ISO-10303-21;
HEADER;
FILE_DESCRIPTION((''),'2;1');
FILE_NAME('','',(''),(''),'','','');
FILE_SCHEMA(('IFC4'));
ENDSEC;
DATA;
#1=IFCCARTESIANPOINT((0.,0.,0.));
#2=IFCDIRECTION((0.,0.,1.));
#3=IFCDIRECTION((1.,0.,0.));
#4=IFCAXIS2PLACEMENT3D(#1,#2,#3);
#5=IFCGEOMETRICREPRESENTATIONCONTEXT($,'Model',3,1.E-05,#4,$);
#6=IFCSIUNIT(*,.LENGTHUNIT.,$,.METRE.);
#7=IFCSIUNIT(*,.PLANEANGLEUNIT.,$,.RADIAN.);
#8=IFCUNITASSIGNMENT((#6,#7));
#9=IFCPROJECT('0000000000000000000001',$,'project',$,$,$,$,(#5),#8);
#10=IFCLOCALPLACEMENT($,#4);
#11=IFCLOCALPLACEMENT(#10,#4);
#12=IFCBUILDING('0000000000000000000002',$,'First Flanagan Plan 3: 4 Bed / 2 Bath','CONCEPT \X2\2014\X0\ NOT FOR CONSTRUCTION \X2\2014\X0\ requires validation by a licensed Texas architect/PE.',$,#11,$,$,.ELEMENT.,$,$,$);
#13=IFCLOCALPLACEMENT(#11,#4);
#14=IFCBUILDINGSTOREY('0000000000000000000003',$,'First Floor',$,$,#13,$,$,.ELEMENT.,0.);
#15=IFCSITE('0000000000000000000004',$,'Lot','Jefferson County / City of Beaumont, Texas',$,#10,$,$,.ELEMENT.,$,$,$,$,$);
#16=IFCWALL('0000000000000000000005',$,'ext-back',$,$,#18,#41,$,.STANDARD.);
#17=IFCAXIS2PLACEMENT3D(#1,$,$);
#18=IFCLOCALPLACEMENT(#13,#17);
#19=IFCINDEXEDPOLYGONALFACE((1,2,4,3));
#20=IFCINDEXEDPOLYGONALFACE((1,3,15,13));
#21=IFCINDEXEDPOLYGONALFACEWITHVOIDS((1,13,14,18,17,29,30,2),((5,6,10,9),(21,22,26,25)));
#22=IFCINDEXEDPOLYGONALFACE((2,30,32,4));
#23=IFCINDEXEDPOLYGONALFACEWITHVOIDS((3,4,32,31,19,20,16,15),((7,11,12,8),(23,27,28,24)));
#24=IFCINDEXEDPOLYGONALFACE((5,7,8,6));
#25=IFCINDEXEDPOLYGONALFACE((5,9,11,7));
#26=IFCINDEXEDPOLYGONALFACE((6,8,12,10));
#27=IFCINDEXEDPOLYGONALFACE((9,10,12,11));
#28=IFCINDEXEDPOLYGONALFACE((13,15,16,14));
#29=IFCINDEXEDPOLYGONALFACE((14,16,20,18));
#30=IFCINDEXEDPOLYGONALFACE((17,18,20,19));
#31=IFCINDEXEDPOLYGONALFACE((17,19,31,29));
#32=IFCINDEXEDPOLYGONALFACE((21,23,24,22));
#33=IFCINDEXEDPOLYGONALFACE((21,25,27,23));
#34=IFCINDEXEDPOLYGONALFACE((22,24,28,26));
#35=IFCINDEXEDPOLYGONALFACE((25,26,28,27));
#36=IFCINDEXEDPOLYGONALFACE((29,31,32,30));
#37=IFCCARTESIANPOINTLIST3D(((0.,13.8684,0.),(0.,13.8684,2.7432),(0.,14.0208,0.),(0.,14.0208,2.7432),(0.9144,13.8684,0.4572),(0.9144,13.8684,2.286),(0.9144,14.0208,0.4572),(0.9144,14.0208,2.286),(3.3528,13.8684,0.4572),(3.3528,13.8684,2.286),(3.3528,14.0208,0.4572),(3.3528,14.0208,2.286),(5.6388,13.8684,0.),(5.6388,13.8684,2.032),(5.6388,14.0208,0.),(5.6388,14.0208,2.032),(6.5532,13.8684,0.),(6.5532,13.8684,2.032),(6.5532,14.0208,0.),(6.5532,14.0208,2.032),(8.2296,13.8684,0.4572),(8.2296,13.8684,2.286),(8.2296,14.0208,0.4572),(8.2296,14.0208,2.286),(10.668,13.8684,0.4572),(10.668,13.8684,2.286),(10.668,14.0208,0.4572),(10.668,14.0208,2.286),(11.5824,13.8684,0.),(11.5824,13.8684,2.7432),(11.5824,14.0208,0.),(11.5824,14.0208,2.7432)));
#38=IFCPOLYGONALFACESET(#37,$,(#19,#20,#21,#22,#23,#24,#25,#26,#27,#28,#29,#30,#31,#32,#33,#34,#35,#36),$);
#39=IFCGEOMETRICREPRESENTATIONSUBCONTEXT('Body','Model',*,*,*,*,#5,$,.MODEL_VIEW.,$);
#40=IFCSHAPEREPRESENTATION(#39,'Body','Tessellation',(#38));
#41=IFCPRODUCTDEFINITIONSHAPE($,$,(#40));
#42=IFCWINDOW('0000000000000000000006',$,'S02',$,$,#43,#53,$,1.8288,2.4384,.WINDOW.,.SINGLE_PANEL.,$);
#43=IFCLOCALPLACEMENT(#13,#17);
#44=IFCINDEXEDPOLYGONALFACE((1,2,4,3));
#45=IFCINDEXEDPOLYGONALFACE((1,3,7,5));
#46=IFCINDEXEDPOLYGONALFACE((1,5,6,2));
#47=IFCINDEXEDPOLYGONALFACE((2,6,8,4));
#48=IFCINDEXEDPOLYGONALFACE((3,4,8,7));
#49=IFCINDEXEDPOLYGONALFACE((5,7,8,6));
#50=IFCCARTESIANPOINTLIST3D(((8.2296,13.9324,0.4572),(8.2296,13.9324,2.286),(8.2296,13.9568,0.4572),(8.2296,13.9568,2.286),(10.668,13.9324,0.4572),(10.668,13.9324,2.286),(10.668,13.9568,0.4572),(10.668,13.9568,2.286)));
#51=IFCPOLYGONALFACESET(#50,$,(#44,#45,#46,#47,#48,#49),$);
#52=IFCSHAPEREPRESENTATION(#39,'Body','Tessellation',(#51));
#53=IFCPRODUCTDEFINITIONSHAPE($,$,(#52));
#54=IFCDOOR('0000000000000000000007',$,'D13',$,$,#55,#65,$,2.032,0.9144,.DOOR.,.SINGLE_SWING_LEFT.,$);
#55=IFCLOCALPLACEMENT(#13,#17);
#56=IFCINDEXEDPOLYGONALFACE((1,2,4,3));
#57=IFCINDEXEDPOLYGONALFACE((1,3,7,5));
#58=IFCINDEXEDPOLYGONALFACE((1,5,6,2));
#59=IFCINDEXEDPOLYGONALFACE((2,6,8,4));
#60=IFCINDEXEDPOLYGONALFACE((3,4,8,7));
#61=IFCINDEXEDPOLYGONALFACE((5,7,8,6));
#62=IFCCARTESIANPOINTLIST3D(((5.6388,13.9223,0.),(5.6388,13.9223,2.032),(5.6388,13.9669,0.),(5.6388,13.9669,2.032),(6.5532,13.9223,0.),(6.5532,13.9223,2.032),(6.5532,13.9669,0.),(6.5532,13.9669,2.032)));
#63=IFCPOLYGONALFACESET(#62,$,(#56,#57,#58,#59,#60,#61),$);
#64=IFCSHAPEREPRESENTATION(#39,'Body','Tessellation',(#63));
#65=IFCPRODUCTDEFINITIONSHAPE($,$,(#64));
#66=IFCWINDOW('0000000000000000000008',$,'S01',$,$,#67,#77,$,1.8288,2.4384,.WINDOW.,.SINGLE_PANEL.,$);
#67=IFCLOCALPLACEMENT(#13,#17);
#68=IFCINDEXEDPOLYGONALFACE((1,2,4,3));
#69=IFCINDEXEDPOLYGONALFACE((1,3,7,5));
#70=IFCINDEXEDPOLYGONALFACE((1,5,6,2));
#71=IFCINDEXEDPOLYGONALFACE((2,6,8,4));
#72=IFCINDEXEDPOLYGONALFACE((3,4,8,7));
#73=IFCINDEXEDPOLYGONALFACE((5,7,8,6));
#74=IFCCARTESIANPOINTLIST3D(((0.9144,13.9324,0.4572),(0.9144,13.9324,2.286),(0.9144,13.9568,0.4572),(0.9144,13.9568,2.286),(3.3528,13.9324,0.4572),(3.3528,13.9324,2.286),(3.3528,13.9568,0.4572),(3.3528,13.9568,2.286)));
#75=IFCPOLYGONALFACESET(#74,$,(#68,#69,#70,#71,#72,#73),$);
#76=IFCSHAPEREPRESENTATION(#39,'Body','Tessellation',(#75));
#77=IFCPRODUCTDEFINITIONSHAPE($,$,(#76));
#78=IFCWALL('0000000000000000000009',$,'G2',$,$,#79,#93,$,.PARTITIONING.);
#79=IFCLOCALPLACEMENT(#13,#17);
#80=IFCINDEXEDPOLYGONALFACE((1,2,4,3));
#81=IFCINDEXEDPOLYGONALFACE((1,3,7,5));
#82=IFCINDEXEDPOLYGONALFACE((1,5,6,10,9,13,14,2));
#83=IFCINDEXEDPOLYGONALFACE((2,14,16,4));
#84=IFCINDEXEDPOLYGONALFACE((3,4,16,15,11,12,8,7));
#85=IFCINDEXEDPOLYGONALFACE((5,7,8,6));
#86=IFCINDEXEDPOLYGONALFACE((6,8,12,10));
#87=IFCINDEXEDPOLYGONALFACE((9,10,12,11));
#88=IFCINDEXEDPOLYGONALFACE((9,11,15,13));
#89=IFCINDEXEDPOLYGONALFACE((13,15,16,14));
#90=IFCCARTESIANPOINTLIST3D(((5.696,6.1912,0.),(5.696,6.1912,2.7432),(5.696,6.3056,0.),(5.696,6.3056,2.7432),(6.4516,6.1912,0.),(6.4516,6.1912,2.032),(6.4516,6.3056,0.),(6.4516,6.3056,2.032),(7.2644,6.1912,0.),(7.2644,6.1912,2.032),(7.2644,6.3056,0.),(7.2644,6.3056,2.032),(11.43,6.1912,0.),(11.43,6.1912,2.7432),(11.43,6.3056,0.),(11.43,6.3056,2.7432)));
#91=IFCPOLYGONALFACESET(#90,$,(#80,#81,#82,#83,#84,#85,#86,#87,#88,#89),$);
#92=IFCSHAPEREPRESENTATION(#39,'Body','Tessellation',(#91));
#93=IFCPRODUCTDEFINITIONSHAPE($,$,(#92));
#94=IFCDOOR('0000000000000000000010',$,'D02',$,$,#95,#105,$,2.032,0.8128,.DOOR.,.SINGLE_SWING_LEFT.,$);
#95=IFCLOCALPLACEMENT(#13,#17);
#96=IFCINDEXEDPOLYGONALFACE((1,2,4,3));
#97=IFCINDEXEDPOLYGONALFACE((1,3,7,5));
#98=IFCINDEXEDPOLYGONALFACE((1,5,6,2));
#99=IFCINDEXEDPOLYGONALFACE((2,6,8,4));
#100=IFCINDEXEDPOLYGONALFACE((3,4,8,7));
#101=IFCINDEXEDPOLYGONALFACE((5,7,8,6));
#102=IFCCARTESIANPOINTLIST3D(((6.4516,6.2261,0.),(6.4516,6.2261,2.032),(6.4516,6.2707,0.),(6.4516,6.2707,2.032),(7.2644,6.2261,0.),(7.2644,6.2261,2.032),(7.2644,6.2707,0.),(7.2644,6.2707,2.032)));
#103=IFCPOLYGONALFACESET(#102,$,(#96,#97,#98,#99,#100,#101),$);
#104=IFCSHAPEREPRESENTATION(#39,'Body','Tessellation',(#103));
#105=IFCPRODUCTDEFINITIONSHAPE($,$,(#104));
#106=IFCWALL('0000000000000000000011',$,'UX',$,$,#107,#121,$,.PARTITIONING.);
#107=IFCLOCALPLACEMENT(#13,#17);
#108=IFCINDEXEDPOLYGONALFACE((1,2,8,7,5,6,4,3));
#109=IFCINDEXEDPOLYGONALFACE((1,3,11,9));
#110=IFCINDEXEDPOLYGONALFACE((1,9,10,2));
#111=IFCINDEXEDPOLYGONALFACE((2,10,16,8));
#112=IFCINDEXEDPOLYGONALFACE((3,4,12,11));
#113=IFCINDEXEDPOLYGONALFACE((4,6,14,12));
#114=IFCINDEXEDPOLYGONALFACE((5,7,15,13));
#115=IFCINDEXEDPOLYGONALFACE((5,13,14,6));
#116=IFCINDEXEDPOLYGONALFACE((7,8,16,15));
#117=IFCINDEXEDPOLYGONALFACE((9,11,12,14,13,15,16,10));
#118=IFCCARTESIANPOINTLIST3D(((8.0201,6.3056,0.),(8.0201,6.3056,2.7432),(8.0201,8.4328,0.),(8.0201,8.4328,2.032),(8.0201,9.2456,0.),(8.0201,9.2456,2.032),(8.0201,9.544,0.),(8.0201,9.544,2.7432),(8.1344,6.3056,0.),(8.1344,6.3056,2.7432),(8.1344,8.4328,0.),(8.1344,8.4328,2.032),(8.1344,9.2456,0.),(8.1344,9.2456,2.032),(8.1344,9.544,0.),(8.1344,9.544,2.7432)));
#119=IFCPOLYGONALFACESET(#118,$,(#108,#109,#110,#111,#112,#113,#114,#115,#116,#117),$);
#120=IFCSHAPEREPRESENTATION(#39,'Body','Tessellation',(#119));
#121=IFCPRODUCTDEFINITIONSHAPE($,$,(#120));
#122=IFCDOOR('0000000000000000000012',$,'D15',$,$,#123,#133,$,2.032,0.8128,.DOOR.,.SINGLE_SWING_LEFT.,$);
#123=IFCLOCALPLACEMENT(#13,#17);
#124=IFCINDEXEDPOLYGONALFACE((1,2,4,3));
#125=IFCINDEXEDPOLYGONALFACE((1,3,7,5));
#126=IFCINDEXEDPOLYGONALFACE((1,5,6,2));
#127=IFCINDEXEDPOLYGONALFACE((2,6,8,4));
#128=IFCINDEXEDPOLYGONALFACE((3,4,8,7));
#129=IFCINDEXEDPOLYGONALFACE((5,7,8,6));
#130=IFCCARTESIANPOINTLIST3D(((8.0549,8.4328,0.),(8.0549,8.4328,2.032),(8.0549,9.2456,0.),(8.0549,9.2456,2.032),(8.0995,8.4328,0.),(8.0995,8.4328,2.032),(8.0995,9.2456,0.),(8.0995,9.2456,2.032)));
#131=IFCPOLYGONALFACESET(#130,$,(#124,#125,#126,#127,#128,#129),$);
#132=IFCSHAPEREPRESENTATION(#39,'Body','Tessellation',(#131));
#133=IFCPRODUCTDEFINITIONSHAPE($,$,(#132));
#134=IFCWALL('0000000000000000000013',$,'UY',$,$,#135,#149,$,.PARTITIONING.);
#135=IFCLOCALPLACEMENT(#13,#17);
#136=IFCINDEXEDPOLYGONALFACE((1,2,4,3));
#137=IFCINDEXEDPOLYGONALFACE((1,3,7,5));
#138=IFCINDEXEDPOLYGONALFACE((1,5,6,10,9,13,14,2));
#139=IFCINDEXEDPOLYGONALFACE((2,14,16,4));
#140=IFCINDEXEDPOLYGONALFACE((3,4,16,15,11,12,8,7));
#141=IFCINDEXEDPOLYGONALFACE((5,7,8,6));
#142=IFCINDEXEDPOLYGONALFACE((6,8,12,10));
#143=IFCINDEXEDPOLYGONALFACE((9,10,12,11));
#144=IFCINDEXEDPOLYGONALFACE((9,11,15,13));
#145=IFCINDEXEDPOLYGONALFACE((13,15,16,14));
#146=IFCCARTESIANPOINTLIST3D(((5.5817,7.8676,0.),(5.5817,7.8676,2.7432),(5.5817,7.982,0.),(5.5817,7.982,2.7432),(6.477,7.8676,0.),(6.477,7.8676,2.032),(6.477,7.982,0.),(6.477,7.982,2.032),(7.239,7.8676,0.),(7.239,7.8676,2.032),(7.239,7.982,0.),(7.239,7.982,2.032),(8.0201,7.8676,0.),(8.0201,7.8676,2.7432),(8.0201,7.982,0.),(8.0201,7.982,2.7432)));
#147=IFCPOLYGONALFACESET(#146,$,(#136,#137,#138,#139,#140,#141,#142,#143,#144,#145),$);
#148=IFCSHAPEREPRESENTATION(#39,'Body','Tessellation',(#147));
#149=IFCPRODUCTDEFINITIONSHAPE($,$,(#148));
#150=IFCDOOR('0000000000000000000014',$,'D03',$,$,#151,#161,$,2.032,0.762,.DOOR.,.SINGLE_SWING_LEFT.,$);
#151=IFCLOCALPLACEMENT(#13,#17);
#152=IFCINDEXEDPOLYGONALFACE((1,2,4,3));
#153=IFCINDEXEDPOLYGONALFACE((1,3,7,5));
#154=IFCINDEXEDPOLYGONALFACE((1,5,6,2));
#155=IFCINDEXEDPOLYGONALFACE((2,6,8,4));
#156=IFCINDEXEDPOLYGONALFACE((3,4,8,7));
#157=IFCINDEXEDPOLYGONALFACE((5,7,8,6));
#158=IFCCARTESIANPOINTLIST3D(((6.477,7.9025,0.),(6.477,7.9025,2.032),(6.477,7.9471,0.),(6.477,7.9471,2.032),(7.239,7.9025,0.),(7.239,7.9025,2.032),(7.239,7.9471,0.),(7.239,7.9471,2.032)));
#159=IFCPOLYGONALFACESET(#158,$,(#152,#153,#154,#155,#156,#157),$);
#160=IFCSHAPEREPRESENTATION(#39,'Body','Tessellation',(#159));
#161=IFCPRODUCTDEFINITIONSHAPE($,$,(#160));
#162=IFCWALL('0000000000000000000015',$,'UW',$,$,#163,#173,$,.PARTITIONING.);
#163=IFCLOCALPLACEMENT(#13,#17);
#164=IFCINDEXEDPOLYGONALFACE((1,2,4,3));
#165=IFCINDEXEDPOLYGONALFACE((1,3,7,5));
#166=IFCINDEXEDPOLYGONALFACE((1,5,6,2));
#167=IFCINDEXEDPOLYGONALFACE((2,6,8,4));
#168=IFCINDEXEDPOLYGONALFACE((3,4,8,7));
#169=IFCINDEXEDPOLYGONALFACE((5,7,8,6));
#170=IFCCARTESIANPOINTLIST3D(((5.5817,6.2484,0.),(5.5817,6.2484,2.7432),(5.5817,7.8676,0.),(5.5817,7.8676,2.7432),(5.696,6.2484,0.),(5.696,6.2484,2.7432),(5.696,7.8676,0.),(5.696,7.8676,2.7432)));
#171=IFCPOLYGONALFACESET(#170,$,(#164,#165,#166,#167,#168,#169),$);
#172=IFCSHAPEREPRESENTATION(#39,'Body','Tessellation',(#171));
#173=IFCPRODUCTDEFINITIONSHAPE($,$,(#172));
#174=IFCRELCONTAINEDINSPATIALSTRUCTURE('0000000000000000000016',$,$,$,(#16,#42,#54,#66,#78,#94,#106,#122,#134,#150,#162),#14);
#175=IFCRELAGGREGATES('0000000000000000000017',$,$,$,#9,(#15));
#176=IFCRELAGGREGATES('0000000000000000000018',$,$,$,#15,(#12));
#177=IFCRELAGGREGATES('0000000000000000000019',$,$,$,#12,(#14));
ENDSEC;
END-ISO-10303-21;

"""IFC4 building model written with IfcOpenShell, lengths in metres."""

from ifc_helpers import new_model, si_unit, frame, frame_2d, origin_with_axes, place, context, subcontext, project, spatial, rectangle, extrude, element, fill, save


model = new_model("IFC4")

# Units and contexts
model_context = context("Model", 3, precision=1e-05, world=origin_with_axes())
body_context = subcontext(model_context, "Body", "Model", "MODEL_VIEW")
ifc_project = project(units=[si_unit("LENGTHUNIT", "METRE"), si_unit("PLANEANGLEUNIT", "RADIAN")], contexts=[model_context])

# Site, building, storey
site_placement = place(None, origin_with_axes())
site = spatial("IfcSite", under=ifc_project, at=site_placement, Name="Lot", Description="Jefferson County / City of Beaumont, Texas", CompositionType="ELEMENT")
building_placement = place(site_placement, origin_with_axes())
building = spatial("IfcBuilding", under=site, at=building_placement, Name="First Flanagan Plan 3: 4 Bed / 2 Bath", Description="CONCEPT — NOT FOR CONSTRUCTION — requires validation by a licensed Texas architect/PE.", CompositionType="ELEMENT")
storey_placement = place(building_placement, origin_with_axes())
storey = spatial("IfcBuildingStorey", under=building, at=storey_placement, Name="First Floor", CompositionType="ELEMENT", Elevation=0.0)

# Wall, openings, windows, door
wall_1_placement = place(storey_placement, frame((11.5824, 13.9446, 0.0), z_axis=(0.0, 0.0, 1.0), x_axis=(-1.0, 0.0, 0.0)))
wall_1 = element("IfcWall", 1, at=wall_1_placement, inside=storey, Name="ext-back", PredefinedType="STANDARD", context=body_context, shape_type="SweptSolid", body=[
    extrude(rectangle(XDim=11.5824, YDim=0.1524, at=frame_2d((5.7912, 0.0), x_axis=(1.0, 0.0))), origin_with_axes(), (0.0, 0.0, 1.0), 2.7432),
])
opening_1_placement = place(wall_1_placement, frame((0.9144, 0.0, 0.4572), z_axis=(0.0, 0.0, 1.0), x_axis=(1.0, 0.0, 0.0)))
opening_1 = element("IfcOpeningElement", 2, at=opening_1_placement, cuts=wall_1, PredefinedType="OPENING", context=body_context, shape_type="SweptSolid", body=[
    extrude(rectangle(XDim=2.4384, YDim=0.1829, at=frame_2d((1.2192, 0.0), x_axis=(1.0, 0.0))), origin_with_axes(), (0.0, 0.0, 1.0), 1.8288),
])
opening_2_placement = place(wall_1_placement, frame((5.0292, 0.0, 0.0), z_axis=(0.0, 0.0, 1.0), x_axis=(1.0, 0.0, 0.0)))
opening_2 = element("IfcOpeningElement", 3, at=opening_2_placement, cuts=wall_1, PredefinedType="OPENING", context=body_context, shape_type="SweptSolid", body=[
    extrude(rectangle(XDim=0.9144, YDim=0.1829, at=frame_2d((0.4572, 0.0), x_axis=(1.0, 0.0))), origin_with_axes(), (0.0, 0.0, 1.0), 2.032),
])
opening_3_placement = place(wall_1_placement, frame((8.2296, 0.0, 0.4572), z_axis=(0.0, 0.0, 1.0), x_axis=(1.0, 0.0, 0.0)))
opening_3 = element("IfcOpeningElement", 4, at=opening_3_placement, cuts=wall_1, PredefinedType="OPENING", context=body_context, shape_type="SweptSolid", body=[
    extrude(rectangle(XDim=2.4384, YDim=0.1829, at=frame_2d((1.2192, 0.0), x_axis=(1.0, 0.0))), origin_with_axes(), (0.0, 0.0, 1.0), 1.8288),
])
window_1_placement = place(opening_1_placement, origin_with_axes())
window_1 = element("IfcWindow", 5, at=window_1_placement, inside=storey, Name="S02", OverallHeight=1.8288, OverallWidth=2.4384, PartitioningType="SINGLE_PANEL", PredefinedType="WINDOW", context=body_context, shape_type="SweptSolid", body=[
    extrude(rectangle(XDim=2.4384, YDim=0.0244, at=frame_2d((1.2192, 0.0), x_axis=(1.0, 0.0))), origin_with_axes(), (0.0, 0.0, 1.0), 1.8288),
])
fill(opening_1, window_1)
door_1_placement = place(opening_2_placement, origin_with_axes())
door_1 = element("IfcDoor", 6, at=door_1_placement, inside=storey, Name="D13", OperationType="SINGLE_SWING_LEFT", OverallHeight=2.032, OverallWidth=0.9144, PredefinedType="DOOR", context=body_context, shape_type="SweptSolid", body=[
    extrude(rectangle(XDim=0.9144, YDim=0.0445, at=frame_2d((0.4572, 0.0), x_axis=(1.0, 0.0))), origin_with_axes(), (0.0, 0.0, 1.0), 2.032),
])
fill(opening_2, door_1)
window_2_placement = place(opening_3_placement, origin_with_axes())
window_2 = element("IfcWindow", 7, at=window_2_placement, inside=storey, Name="S01", OverallHeight=1.8288, OverallWidth=2.4384, PartitioningType="SINGLE_PANEL", PredefinedType="WINDOW", context=body_context, shape_type="SweptSolid", body=[
    extrude(rectangle(XDim=2.4384, YDim=0.0244, at=frame_2d((1.2192, 0.0), x_axis=(1.0, 0.0))), origin_with_axes(), (0.0, 0.0, 1.0), 1.8288),
])
fill(opening_3, window_2)

# Walls, openings, doors
wall_2_placement = place(storey_placement, frame((5.6959, 6.2484, 0.0), z_axis=(0.0, 0.0, 1.0), x_axis=(1.0, 0.0, 0.0)))
wall_2 = element("IfcWall", 8, at=wall_2_placement, inside=storey, Name="G2", PredefinedType="PARTITIONING", context=body_context, shape_type="SweptSolid", body=[
    extrude(rectangle(XDim=5.734, YDim=0.1143, at=frame_2d((2.867, 0.0), x_axis=(1.0, 0.0))), origin_with_axes(), (0.0, 0.0, 1.0), 2.7432),
])
opening_4_placement = place(wall_2_placement, frame((0.7556, 0.0, 0.0), z_axis=(0.0, 0.0, 1.0), x_axis=(1.0, 0.0, 0.0)))
opening_4 = element("IfcOpeningElement", 9, at=opening_4_placement, cuts=wall_2, PredefinedType="OPENING", context=body_context, shape_type="SweptSolid", body=[
    extrude(rectangle(XDim=0.8128, YDim=0.1448, at=frame_2d((0.4064, 0.0), x_axis=(1.0, 0.0))), origin_with_axes(), (0.0, 0.0, 1.0), 2.032),
])
door_2_placement = place(opening_4_placement, origin_with_axes())
door_2 = element("IfcDoor", 10, at=door_2_placement, inside=storey, Name="D02", OperationType="SINGLE_SWING_LEFT", OverallHeight=2.032, OverallWidth=0.8128, PredefinedType="DOOR", context=body_context, shape_type="SweptSolid", body=[
    extrude(rectangle(XDim=0.8128, YDim=0.0445, at=frame_2d((0.4064, 0.0), x_axis=(1.0, 0.0))), origin_with_axes(), (0.0, 0.0, 1.0), 2.032),
])
fill(opening_4, door_2)
wall_3_placement = place(storey_placement, frame((8.0772, 6.3056, 0.0), z_axis=(0.0, 0.0, 1.0), x_axis=(0.0, 1.0, 0.0)))
wall_3 = element("IfcWall", 11, at=wall_3_placement, inside=storey, Name="UX", PredefinedType="PARTITIONING", context=body_context, shape_type="SweptSolid", body=[
    extrude(rectangle(XDim=3.2385, YDim=0.1143, at=frame_2d((1.6193, 0.0), x_axis=(1.0, 0.0))), origin_with_axes(), (0.0, 0.0, 1.0), 2.7432),
])
opening_5_placement = place(wall_3_placement, frame((2.1272, 0.0, 0.0), z_axis=(0.0, 0.0, 1.0), x_axis=(1.0, 0.0, 0.0)))
opening_5 = element("IfcOpeningElement", 12, at=opening_5_placement, cuts=wall_3, PredefinedType="OPENING", context=body_context, shape_type="SweptSolid", body=[
    extrude(rectangle(XDim=0.8128, YDim=0.1448, at=frame_2d((0.4064, 0.0), x_axis=(1.0, 0.0))), origin_with_axes(), (0.0, 0.0, 1.0), 2.032),
])
door_3_placement = place(opening_5_placement, origin_with_axes())
door_3 = element("IfcDoor", 13, at=door_3_placement, inside=storey, Name="D15", OperationType="SINGLE_SWING_LEFT", OverallHeight=2.032, OverallWidth=0.8128, PredefinedType="DOOR", context=body_context, shape_type="SweptSolid", body=[
    extrude(rectangle(XDim=0.8128, YDim=0.0445, at=frame_2d((0.4064, 0.0), x_axis=(1.0, 0.0))), origin_with_axes(), (0.0, 0.0, 1.0), 2.032),
])
fill(opening_5, door_3)
wall_4_placement = place(storey_placement, frame((5.5817, 7.9248, 0.0), z_axis=(0.0, 0.0, 1.0), x_axis=(1.0, 0.0, 0.0)))
wall_4 = element("IfcWall", 14, at=wall_4_placement, inside=storey, Name="UY", PredefinedType="PARTITIONING", context=body_context, shape_type="SweptSolid", body=[
    extrude(rectangle(XDim=2.4384, YDim=0.1143, at=frame_2d((1.2192, 0.0), x_axis=(1.0, 0.0))), origin_with_axes(), (0.0, 0.0, 1.0), 2.7432),
])
opening_6_placement = place(wall_4_placement, frame((0.8954, 0.0, 0.0), z_axis=(0.0, 0.0, 1.0), x_axis=(1.0, 0.0, 0.0)))
opening_6 = element("IfcOpeningElement", 15, at=opening_6_placement, cuts=wall_4, PredefinedType="OPENING", context=body_context, shape_type="SweptSolid", body=[
    extrude(rectangle(XDim=0.762, YDim=0.1448, at=frame_2d((0.381, 0.0), x_axis=(1.0, 0.0))), origin_with_axes(), (0.0, 0.0, 1.0), 2.032),
])
door_4_placement = place(opening_6_placement, origin_with_axes())
door_4 = element("IfcDoor", 16, at=door_4_placement, inside=storey, Name="D03", OperationType="SINGLE_SWING_LEFT", OverallHeight=2.032, OverallWidth=0.762, PredefinedType="DOOR", context=body_context, shape_type="SweptSolid", body=[
    extrude(rectangle(XDim=0.762, YDim=0.0445, at=frame_2d((0.381, 0.0), x_axis=(1.0, 0.0))), origin_with_axes(), (0.0, 0.0, 1.0), 2.032),
])
fill(opening_6, door_4)

# Wall
wall_5_placement = place(storey_placement, frame((5.6388, 6.2484, 0.0), z_axis=(0.0, 0.0, 1.0), x_axis=(0.0, 1.0, 0.0)))
element("IfcWall", 17, at=wall_5_placement, inside=storey, Name="UW", PredefinedType="PARTITIONING", context=body_context, shape_type="SweptSolid", body=[
    extrude(rectangle(XDim=1.6193, YDim=0.1143, at=frame_2d((0.8096, 0.0), x_axis=(1.0, 0.0))), origin_with_axes(), (0.0, 0.0, 1.0), 2.7432),
])

save(model, "model.ifc")
